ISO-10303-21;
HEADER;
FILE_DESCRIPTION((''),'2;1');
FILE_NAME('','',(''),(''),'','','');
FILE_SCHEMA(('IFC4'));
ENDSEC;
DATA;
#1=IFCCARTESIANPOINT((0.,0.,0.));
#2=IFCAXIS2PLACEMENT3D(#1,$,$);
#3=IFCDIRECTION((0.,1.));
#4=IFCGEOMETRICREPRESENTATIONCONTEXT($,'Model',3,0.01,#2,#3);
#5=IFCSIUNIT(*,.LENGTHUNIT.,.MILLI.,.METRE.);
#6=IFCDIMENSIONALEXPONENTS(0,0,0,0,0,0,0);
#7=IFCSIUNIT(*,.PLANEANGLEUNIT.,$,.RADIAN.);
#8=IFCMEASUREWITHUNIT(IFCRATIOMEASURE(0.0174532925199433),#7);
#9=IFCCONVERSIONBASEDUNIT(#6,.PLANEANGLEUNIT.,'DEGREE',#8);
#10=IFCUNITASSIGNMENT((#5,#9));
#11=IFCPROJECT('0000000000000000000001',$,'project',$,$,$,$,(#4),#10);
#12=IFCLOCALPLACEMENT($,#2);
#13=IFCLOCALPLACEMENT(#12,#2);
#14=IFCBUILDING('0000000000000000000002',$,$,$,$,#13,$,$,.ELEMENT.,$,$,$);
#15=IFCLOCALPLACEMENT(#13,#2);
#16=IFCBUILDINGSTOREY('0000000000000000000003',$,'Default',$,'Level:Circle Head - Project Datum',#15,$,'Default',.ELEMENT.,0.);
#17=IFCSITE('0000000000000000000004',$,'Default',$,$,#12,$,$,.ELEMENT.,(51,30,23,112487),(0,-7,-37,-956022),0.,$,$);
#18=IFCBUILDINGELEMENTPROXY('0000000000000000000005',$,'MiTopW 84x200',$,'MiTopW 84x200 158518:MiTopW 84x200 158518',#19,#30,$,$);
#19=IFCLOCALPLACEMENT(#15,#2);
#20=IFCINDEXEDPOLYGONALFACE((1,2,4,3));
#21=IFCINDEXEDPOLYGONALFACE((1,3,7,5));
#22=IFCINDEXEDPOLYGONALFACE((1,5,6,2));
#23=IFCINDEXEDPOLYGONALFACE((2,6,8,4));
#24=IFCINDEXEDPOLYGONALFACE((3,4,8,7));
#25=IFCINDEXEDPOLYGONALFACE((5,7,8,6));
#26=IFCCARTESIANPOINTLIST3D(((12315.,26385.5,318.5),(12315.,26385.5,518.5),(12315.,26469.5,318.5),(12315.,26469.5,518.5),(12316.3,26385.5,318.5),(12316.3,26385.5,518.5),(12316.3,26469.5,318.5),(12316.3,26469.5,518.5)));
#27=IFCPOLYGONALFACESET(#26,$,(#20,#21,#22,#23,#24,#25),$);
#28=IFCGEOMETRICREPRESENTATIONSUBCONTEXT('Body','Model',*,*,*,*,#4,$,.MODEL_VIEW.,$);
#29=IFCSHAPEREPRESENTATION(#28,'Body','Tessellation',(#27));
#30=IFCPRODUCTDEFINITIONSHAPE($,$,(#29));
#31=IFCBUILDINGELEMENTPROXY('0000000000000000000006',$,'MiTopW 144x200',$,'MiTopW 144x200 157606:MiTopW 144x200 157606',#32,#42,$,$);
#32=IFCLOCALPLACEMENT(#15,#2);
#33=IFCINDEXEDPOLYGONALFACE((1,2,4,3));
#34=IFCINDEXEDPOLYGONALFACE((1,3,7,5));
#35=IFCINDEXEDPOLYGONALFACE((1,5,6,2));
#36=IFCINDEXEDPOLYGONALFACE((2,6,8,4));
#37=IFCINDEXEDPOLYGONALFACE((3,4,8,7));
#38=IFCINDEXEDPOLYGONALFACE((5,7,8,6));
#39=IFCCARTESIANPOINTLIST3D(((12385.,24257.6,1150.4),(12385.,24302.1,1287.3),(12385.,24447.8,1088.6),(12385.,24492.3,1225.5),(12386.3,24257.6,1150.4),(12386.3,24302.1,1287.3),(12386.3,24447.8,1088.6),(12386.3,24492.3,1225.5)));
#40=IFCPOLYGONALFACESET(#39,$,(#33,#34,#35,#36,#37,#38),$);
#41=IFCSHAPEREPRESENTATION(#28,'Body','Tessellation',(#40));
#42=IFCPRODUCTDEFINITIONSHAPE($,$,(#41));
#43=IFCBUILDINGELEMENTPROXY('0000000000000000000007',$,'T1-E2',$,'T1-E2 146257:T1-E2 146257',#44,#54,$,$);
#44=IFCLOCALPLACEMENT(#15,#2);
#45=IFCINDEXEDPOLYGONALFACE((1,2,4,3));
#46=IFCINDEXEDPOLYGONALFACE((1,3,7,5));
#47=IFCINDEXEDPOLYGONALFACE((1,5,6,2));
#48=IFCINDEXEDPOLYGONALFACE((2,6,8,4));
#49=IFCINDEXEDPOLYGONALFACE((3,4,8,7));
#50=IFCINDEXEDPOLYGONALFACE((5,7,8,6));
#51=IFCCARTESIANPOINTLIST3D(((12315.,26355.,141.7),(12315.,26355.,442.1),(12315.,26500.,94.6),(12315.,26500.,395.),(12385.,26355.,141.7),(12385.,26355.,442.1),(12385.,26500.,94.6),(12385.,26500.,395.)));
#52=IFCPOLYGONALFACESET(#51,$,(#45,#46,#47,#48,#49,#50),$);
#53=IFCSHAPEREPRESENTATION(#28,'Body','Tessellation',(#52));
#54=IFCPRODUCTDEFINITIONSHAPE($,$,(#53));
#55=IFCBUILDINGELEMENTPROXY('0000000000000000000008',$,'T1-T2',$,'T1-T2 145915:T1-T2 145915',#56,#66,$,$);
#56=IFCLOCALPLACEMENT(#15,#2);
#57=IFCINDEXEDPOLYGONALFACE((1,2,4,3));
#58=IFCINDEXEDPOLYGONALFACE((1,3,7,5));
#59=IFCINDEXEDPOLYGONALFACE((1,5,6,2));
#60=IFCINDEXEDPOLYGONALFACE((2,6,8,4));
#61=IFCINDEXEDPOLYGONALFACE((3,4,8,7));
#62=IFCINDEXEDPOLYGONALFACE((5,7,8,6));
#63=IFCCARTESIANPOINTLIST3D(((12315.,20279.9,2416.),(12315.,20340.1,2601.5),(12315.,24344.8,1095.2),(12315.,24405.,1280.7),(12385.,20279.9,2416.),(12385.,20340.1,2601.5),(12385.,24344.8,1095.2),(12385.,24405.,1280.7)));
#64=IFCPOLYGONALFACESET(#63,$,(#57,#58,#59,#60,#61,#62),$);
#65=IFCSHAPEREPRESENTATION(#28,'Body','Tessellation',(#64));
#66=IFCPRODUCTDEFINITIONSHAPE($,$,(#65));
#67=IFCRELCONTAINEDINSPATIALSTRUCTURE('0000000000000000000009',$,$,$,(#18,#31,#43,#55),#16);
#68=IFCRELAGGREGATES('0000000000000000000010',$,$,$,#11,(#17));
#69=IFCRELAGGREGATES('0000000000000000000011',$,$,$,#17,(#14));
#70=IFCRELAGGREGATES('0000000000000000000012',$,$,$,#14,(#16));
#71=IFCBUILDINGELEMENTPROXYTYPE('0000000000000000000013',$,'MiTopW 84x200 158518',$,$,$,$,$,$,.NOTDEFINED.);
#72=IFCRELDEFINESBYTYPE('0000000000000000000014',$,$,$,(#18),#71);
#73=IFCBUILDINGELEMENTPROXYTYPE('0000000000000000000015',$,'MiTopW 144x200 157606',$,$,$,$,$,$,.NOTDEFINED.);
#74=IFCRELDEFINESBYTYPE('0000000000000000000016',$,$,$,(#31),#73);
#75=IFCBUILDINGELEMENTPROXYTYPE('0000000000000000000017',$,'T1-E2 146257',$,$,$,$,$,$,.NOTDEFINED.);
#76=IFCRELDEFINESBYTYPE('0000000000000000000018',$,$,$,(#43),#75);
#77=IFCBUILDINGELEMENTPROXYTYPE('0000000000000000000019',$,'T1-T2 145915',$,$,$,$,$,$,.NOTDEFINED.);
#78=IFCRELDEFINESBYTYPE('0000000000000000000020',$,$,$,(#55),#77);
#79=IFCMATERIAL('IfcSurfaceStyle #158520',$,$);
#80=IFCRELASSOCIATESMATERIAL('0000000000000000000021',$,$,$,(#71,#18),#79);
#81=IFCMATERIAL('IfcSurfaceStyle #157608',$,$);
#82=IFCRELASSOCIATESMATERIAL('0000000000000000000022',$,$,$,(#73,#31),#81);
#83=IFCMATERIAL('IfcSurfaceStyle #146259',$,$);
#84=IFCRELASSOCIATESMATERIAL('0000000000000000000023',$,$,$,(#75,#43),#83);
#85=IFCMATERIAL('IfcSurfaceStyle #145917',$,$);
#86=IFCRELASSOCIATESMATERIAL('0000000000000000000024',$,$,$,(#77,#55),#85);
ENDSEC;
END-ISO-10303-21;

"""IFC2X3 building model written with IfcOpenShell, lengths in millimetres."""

from ifc_helpers import new_model, entity, si_unit, converted_unit, direction, frame, frame_2d, origin, place, context, subcontext, project, spatial, polyline, rectangle, outline, extrude, source, transform, mapped, material, type_object, type_shapes, element, save


model = new_model("IFC2X3")

# Units and contexts
model_context = context("Model", 3, precision=0.01, world=origin(), true_north=direction((0.0, 1.0)))
body_context = subcontext(model_context, "Body", "Model", "MODEL_VIEW")
ifc_project = project(units=[si_unit("LENGTHUNIT", "METRE", prefix="MILLI"), converted_unit("PLANEANGLEUNIT", "DEGREE", entity("IfcRatioMeasure", 0.0174532925199433), si_unit("PLANEANGLEUNIT", "RADIAN"), dimensions=[0, 0, 0, 0, 0, 0, 0])], contexts=[model_context])

# Site, building, storey
site_placement = place(None, origin())
site = spatial("IfcSite", under=ifc_project, at=site_placement, Name="Default", CompositionType="ELEMENT", RefLatitude=(51, 30, 23, 112487), RefLongitude=(0, -7, -37, -956022), RefElevation=0.0)
building_placement = place(site_placement, origin())
building = spatial("IfcBuilding", under=site, at=building_placement, CompositionType="ELEMENT")
storey_placement = place(building_placement, origin())
storey = spatial("IfcBuildingStorey", under=building, at=storey_placement, Name="Default", ObjectType="Level:Circle Head - Project Datum", LongName="Default", CompositionType="ELEMENT", Elevation=0.0)

# Building element proxies
ifc_material_1 = material(Name="IfcSurfaceStyle #158520")
building_element_proxy_type_1 = type_object("IfcBuildingElementProxyType", Name="MiTopW 84x200 158518", PredefinedType="NOTDEFINED", material=ifc_material_1)
shared_shape_1 = source(origin(), body_context, "Body", "SweptSolid", [
    extrude(rectangle(XDim=200.0, YDim=84.0, at=frame_2d((0.0, 0.0), x_axis=(1.0, 0.0))), frame((100.0, 42.0, 0.0), z_axis=(0.0, 0.0, 1.0), x_axis=(-1.0, 0.0, 0.0)), (0.0, 0.0, 1.0), 1.3),
])
type_shapes(building_element_proxy_type_1, [shared_shape_1])
proxy_1_placement = place(building_placement, frame((12316.3, 26469.5, 518.5), z_axis=(-1.0, 0.0, 0.0), x_axis=(0.0, 0.0, -1.0)))
element("IfcBuildingElementProxy", 1, at=proxy_1_placement, inside=storey, type_object=building_element_proxy_type_1, material=ifc_material_1, Name="MiTopW 84x200", ObjectType="MiTopW 84x200 158518:MiTopW 84x200 158518", context=body_context, shape_type="MappedRepresentation", body=[
    mapped(shared_shape_1, transform((0.0, 0.0, 0.0), scale=1.0)),
])
ifc_material_2 = material(Name="IfcSurfaceStyle #157608")
building_element_proxy_type_2 = type_object("IfcBuildingElementProxyType", Name="MiTopW 144x200 157606", PredefinedType="NOTDEFINED", material=ifc_material_2)
shared_shape_2 = source(origin(), body_context, "Body", "SweptSolid", [
    extrude(outline(polyline([(-100.0, -72.0), (100.0, -72.0), (100.0, 72.0), (-100.0, 72.0), (-100.0, -72.0)])), frame((100.0, 72.0, 0.0), z_axis=(0.0, 0.0, 1.0), x_axis=(-1.0, 0.0, 0.0)), (0.0, 0.0, 1.0), 1.3),
])
type_shapes(building_element_proxy_type_2, [shared_shape_2])
proxy_2_placement = place(building_placement, frame((12386.3, 24447.8, 1088.6), z_axis=(-1.0, 0.0, 0.0), x_axis=(0.0, -0.951057, 0.309017)))
element("IfcBuildingElementProxy", 2, at=proxy_2_placement, inside=storey, type_object=building_element_proxy_type_2, material=ifc_material_2, Name="MiTopW 144x200", ObjectType="MiTopW 144x200 157606:MiTopW 144x200 157606", context=body_context, shape_type="MappedRepresentation", body=[
    mapped(shared_shape_2, transform((0.0, 0.0, 0.0), scale=1.0)),
])
ifc_material_3 = material(Name="IfcSurfaceStyle #146259")
building_element_proxy_type_3 = type_object("IfcBuildingElementProxyType", Name="T1-E2 146257", PredefinedType="NOTDEFINED", material=ifc_material_3)
shared_shape_3 = source(origin(), body_context, "Body", "SweptSolid", [
    extrude(outline(polyline([(-126.6, -72.5), (173.8, -72.5), (126.6, 72.5), (-173.8, 72.5), (-126.6, -72.5)])), frame((173.8, 72.5, 0.0), z_axis=(0.0, 0.0, 1.0), x_axis=(-1.0, 0.0, 0.0)), (0.0, 0.0, 1.0), 70.0),
])
type_shapes(building_element_proxy_type_3, [shared_shape_3])
proxy_3_placement = place(building_placement, frame((12385.0, 26500.0, 442.1), z_axis=(-1.0, 0.0, 0.0), x_axis=(0.0, 0.0, -1.0)))
element("IfcBuildingElementProxy", 3, at=proxy_3_placement, inside=storey, type_object=building_element_proxy_type_3, material=ifc_material_3, Name="T1-E2", ObjectType="T1-E2 146257:T1-E2 146257", context=body_context, shape_type="MappedRepresentation", body=[
    mapped(shared_shape_3, transform((0.0, 0.0, 0.0), scale=1.0)),
])
ifc_material_4 = material(Name="IfcSurfaceStyle #145917")
building_element_proxy_type_4 = type_object("IfcBuildingElementProxyType", Name="T1-T2 145915", PredefinedType="NOTDEFINED", material=ifc_material_4)
shared_shape_4 = source(origin(), body_context, "Body", "SweptSolid", [
    extrude(outline(polyline([(-2137.0, -97.5), (2137.0, -97.5), (2137.0, 97.5), (-2137.0, 97.5), (-2137.0, -97.5)])), frame((2137.0, 97.5, 0.0), z_axis=(0.0, 0.0, 1.0), x_axis=(-1.0, 0.0, 0.0)), (0.0, 0.0, 1.0), 70.0),
])
type_shapes(building_element_proxy_type_4, [shared_shape_4])
proxy_4_placement = place(building_placement, frame((12385.0, 24344.8, 1095.2), z_axis=(-1.0, 0.0, 0.0), x_axis=(0.0, -0.951057, 0.309017)))
element("IfcBuildingElementProxy", 4, at=proxy_4_placement, inside=storey, type_object=building_element_proxy_type_4, material=ifc_material_4, Name="T1-T2", ObjectType="T1-T2 145915:T1-T2 145915", context=body_context, shape_type="MappedRepresentation", body=[
    mapped(shared_shape_4, transform((0.0, 0.0, 0.0), scale=1.0)),
])

save(model, "model.ifc")
